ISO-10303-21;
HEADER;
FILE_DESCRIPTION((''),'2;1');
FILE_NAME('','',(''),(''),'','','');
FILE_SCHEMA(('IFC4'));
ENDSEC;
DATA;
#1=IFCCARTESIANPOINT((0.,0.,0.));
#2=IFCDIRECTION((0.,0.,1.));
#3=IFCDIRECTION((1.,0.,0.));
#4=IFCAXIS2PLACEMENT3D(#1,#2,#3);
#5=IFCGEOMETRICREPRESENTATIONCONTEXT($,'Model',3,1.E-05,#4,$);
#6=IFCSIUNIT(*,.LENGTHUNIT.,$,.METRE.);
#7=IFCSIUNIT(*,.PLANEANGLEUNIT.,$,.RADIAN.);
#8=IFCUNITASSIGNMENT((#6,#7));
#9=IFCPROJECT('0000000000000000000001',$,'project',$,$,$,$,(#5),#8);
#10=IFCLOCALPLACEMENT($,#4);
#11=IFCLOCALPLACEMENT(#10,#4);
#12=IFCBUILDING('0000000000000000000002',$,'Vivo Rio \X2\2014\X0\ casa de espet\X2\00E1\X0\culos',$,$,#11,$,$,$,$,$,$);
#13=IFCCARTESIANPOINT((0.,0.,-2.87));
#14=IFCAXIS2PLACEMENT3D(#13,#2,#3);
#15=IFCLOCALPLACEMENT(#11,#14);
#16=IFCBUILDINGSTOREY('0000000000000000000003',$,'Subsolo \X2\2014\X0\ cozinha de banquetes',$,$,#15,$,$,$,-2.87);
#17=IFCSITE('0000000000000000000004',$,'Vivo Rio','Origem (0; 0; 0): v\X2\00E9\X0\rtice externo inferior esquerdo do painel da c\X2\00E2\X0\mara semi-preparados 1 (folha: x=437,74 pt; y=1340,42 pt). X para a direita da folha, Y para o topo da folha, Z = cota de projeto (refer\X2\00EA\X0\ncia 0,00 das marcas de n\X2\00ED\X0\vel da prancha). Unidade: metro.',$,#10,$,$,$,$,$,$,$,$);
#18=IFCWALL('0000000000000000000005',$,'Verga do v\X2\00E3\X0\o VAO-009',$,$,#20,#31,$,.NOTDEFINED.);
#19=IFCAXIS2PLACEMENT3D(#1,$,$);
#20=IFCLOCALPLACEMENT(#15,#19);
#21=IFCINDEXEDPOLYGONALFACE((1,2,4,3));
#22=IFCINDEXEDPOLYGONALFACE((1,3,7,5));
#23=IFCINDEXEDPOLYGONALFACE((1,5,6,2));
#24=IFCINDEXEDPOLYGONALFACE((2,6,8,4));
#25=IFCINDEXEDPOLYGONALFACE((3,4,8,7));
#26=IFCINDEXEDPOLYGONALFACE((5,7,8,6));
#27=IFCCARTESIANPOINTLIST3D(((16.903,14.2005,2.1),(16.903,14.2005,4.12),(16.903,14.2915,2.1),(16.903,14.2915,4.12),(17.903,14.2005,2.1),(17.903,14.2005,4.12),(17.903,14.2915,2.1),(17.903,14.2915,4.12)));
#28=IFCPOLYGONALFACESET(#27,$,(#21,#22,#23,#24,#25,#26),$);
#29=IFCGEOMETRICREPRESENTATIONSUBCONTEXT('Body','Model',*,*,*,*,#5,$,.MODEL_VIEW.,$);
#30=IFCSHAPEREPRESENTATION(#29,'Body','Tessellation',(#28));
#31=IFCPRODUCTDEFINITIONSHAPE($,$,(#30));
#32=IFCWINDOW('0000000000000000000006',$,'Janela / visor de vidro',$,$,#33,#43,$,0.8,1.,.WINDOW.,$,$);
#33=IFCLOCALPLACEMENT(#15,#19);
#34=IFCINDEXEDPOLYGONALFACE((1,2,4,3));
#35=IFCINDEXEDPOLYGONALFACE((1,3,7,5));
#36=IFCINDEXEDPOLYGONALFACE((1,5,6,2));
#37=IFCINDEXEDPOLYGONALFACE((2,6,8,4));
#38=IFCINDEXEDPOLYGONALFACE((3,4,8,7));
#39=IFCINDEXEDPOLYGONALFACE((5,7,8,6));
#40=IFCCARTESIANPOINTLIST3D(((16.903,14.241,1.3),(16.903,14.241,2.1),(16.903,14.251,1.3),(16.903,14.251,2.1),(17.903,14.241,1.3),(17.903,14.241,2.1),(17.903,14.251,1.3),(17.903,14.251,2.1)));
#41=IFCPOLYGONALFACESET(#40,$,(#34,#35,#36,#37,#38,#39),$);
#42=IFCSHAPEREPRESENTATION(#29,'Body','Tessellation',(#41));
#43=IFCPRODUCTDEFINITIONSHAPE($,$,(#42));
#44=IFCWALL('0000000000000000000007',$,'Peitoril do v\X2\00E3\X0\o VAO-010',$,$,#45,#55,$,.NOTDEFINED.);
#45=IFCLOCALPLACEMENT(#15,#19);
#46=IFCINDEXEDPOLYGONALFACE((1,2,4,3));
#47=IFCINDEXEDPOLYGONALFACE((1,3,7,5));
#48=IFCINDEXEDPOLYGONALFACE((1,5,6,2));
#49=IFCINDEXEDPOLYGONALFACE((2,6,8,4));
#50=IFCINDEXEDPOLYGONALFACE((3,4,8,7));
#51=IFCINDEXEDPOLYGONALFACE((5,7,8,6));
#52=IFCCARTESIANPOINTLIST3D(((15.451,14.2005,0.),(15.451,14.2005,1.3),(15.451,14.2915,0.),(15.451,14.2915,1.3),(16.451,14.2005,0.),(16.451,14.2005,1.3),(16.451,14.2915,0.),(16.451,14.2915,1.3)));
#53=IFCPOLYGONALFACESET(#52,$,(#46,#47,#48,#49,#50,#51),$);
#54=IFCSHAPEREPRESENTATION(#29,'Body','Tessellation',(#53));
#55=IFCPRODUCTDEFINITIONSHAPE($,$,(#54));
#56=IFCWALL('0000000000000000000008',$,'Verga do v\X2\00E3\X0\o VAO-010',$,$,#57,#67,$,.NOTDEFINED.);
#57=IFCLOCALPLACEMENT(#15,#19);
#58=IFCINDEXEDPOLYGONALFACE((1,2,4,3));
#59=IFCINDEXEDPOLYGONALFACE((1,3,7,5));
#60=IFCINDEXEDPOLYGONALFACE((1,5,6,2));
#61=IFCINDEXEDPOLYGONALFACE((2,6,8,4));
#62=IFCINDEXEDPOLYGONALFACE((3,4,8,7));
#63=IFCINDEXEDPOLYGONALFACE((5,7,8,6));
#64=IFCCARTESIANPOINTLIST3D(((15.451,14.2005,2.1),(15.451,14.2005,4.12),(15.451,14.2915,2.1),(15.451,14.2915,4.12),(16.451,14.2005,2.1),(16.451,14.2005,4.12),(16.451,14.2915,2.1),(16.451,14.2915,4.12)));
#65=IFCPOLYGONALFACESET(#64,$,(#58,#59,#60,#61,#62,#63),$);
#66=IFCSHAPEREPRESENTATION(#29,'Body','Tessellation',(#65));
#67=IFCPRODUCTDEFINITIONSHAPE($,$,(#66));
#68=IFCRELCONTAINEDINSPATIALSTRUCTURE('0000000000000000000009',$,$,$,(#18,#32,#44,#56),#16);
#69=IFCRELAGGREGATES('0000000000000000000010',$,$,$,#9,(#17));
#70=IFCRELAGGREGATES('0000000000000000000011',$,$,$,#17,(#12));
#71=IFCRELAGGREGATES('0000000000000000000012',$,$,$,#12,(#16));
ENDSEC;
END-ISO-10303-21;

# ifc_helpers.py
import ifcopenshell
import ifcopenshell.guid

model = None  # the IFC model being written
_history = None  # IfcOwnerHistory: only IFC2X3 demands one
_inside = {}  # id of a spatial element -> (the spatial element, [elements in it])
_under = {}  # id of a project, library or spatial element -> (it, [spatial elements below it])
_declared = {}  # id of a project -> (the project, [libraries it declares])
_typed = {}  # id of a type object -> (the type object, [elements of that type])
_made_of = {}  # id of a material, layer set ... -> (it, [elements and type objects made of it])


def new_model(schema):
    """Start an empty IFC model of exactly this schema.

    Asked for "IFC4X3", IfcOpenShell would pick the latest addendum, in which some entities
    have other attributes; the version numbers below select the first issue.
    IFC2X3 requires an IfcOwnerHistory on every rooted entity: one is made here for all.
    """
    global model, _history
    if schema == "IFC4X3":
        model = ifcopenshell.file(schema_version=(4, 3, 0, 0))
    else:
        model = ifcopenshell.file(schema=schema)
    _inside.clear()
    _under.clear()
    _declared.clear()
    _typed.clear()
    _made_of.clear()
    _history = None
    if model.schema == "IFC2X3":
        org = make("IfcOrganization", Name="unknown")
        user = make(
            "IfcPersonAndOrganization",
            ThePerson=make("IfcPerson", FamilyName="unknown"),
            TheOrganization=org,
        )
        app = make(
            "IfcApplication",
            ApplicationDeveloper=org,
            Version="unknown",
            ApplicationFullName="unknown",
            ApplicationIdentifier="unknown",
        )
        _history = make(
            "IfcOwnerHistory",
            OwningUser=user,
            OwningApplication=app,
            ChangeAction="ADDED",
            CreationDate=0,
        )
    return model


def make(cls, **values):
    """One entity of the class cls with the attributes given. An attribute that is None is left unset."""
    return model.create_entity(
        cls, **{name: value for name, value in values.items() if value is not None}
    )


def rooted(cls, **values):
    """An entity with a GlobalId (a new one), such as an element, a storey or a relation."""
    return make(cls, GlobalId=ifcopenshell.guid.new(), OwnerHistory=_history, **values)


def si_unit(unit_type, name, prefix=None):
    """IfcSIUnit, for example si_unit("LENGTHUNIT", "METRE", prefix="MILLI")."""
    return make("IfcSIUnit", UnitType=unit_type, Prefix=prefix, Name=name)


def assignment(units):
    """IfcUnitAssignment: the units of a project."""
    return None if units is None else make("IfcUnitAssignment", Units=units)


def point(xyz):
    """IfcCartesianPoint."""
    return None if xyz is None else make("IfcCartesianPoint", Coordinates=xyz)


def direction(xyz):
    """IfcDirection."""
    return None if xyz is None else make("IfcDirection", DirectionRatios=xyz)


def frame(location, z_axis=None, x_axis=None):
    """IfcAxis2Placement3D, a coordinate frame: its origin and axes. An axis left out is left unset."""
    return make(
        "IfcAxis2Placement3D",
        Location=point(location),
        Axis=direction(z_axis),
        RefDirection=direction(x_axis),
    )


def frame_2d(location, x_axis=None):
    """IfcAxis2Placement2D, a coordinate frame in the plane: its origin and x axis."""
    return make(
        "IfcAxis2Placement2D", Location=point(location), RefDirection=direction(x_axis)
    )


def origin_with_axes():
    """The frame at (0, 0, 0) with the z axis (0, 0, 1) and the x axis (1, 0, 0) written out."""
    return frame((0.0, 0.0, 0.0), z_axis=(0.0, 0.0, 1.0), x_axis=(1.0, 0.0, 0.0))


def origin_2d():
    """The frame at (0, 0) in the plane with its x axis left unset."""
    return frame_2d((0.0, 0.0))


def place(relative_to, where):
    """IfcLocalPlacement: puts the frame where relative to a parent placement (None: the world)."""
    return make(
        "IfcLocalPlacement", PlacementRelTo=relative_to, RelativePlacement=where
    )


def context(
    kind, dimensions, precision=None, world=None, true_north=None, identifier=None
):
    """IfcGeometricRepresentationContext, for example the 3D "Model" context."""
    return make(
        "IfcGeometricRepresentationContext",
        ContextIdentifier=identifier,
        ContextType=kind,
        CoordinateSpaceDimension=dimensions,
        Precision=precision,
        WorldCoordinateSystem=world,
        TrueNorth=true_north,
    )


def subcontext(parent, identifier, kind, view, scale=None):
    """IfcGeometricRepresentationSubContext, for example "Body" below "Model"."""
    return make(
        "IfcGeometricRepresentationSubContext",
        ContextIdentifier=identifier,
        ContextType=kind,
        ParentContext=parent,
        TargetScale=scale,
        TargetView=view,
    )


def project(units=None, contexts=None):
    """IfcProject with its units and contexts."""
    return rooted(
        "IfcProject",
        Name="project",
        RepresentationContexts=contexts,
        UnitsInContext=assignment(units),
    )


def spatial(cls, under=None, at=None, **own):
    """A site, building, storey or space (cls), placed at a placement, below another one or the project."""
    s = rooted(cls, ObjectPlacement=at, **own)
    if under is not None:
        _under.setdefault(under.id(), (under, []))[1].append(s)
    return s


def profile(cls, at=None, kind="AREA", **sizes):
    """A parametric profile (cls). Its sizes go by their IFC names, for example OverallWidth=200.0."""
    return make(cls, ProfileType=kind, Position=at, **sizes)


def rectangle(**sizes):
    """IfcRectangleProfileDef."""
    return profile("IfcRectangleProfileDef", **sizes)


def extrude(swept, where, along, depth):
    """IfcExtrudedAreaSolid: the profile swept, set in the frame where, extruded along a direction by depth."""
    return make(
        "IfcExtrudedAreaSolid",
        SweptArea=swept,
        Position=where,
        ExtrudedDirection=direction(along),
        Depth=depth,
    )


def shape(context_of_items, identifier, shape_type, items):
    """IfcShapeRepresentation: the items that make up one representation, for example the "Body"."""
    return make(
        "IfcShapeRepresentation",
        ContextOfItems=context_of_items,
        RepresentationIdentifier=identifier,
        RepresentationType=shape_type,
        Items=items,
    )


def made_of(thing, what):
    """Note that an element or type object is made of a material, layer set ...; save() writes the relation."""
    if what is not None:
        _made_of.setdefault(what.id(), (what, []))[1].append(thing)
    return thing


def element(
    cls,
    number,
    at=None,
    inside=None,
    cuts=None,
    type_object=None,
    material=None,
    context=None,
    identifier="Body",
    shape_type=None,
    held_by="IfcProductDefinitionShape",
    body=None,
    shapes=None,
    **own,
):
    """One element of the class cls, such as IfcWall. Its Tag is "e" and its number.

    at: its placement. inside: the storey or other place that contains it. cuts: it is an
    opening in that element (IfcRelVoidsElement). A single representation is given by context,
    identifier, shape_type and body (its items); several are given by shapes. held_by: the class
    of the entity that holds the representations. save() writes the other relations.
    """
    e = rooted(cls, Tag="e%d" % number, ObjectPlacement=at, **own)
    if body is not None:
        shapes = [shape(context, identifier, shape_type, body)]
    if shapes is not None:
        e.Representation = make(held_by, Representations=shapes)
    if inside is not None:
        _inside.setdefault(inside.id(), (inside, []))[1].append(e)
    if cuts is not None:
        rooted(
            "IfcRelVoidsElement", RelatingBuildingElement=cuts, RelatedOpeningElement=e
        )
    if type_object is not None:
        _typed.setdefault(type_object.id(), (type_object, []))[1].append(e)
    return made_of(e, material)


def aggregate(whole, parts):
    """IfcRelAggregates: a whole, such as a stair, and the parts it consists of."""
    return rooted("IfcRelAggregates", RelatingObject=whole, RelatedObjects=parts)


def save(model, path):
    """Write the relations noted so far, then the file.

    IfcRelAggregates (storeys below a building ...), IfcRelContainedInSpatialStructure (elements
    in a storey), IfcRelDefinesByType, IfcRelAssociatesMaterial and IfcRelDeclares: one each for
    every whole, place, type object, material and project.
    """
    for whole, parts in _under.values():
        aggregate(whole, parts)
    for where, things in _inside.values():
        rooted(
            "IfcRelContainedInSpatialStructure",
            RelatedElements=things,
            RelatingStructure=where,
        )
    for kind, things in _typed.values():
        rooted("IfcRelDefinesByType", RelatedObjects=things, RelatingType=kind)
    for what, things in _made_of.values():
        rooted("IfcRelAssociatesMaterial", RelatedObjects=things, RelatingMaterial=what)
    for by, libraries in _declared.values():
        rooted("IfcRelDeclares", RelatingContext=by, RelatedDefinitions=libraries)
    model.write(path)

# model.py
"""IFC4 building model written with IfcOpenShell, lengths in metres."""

from ifc_helpers import new_model, si_unit, frame, origin_with_axes, origin_2d, place, context, subcontext, project, spatial, rectangle, extrude, element, save


model = new_model("IFC4")

# Units and contexts
model_context = context("Model", 3, precision=1e-05, world=origin_with_axes())
body_context = subcontext(model_context, "Body", "Model", "MODEL_VIEW")
ifc_project = project(units=[si_unit("LENGTHUNIT", "METRE"), si_unit("PLANEANGLEUNIT", "RADIAN")], contexts=[model_context])

# Site, building, storey
site_placement = place(None, origin_with_axes())
site = spatial("IfcSite", under=ifc_project, at=site_placement, Name="Vivo Rio", Description="Origem (0; 0; 0): vértice externo inferior esquerdo do painel da câmara semi-preparados 1 (folha: x=437,74 pt; y=1340,42 pt). X para a direita da folha, Y para o topo da folha, Z = cota de projeto (referência 0,00 das marcas de nível da prancha). Unidade: metro.")
building_placement = place(site_placement, origin_with_axes())
building = spatial("IfcBuilding", under=site, at=building_placement, Name="Vivo Rio — casa de espetáculos")
storey_placement = place(building_placement, frame((0.0, 0.0, -2.87), z_axis=(0.0, 0.0, 1.0), x_axis=(1.0, 0.0, 0.0)))
storey = spatial("IfcBuildingStorey", under=building, at=storey_placement, Name="Subsolo — cozinha de banquetes", Elevation=-2.87)

# Wall
wall_1_placement = place(storey_placement, origin_with_axes())
element("IfcWall", 1, at=wall_1_placement, inside=storey, Name="Verga do vão VAO-009", PredefinedType="NOTDEFINED", context=body_context, shape_type="SweptSolid", body=[
    extrude(rectangle(XDim=1.0, YDim=0.091, at=origin_2d()), frame((17.403, 14.246, 2.1), z_axis=(0.0, 0.0, 1.0), x_axis=(1.0, 0.0, 0.0)), (0.0, 0.0, 1.0), 2.02),
])

# Window
window_1_placement = place(storey_placement, origin_with_axes())
element("IfcWindow", 2, at=window_1_placement, inside=storey, Name="Janela / visor de vidro", OverallHeight=0.8, OverallWidth=1.0, PredefinedType="WINDOW", context=body_context, shape_type="SweptSolid", body=[
    extrude(rectangle(XDim=1.0, YDim=0.01, at=origin_2d()), frame((17.403, 14.246, 1.3), z_axis=(0.0, 0.0, 1.0), x_axis=(1.0, 0.0, 0.0)), (0.0, 0.0, 1.0), 0.8),
])

# Walls
wall_2_placement = place(storey_placement, origin_with_axes())
element("IfcWall", 3, at=wall_2_placement, inside=storey, Name="Peitoril do vão VAO-010", PredefinedType="NOTDEFINED", context=body_context, shape_type="SweptSolid", body=[
    extrude(rectangle(XDim=1.0, YDim=0.091, at=origin_2d()), frame((15.951, 14.246, 0.0), z_axis=(0.0, 0.0, 1.0), x_axis=(1.0, 0.0, 0.0)), (0.0, 0.0, 1.0), 1.3),
])
wall_3_placement = place(storey_placement, origin_with_axes())
element("IfcWall", 4, at=wall_3_placement, inside=storey, Name="Verga do vão VAO-010", PredefinedType="NOTDEFINED", context=body_context, shape_type="SweptSolid", body=[
    extrude(rectangle(XDim=1.0, YDim=0.091, at=origin_2d()), frame((15.951, 14.246, 2.1), z_axis=(0.0, 0.0, 1.0), x_axis=(1.0, 0.0, 0.0)), (0.0, 0.0, 1.0), 2.02),
])

save(model, "model.ifc")
